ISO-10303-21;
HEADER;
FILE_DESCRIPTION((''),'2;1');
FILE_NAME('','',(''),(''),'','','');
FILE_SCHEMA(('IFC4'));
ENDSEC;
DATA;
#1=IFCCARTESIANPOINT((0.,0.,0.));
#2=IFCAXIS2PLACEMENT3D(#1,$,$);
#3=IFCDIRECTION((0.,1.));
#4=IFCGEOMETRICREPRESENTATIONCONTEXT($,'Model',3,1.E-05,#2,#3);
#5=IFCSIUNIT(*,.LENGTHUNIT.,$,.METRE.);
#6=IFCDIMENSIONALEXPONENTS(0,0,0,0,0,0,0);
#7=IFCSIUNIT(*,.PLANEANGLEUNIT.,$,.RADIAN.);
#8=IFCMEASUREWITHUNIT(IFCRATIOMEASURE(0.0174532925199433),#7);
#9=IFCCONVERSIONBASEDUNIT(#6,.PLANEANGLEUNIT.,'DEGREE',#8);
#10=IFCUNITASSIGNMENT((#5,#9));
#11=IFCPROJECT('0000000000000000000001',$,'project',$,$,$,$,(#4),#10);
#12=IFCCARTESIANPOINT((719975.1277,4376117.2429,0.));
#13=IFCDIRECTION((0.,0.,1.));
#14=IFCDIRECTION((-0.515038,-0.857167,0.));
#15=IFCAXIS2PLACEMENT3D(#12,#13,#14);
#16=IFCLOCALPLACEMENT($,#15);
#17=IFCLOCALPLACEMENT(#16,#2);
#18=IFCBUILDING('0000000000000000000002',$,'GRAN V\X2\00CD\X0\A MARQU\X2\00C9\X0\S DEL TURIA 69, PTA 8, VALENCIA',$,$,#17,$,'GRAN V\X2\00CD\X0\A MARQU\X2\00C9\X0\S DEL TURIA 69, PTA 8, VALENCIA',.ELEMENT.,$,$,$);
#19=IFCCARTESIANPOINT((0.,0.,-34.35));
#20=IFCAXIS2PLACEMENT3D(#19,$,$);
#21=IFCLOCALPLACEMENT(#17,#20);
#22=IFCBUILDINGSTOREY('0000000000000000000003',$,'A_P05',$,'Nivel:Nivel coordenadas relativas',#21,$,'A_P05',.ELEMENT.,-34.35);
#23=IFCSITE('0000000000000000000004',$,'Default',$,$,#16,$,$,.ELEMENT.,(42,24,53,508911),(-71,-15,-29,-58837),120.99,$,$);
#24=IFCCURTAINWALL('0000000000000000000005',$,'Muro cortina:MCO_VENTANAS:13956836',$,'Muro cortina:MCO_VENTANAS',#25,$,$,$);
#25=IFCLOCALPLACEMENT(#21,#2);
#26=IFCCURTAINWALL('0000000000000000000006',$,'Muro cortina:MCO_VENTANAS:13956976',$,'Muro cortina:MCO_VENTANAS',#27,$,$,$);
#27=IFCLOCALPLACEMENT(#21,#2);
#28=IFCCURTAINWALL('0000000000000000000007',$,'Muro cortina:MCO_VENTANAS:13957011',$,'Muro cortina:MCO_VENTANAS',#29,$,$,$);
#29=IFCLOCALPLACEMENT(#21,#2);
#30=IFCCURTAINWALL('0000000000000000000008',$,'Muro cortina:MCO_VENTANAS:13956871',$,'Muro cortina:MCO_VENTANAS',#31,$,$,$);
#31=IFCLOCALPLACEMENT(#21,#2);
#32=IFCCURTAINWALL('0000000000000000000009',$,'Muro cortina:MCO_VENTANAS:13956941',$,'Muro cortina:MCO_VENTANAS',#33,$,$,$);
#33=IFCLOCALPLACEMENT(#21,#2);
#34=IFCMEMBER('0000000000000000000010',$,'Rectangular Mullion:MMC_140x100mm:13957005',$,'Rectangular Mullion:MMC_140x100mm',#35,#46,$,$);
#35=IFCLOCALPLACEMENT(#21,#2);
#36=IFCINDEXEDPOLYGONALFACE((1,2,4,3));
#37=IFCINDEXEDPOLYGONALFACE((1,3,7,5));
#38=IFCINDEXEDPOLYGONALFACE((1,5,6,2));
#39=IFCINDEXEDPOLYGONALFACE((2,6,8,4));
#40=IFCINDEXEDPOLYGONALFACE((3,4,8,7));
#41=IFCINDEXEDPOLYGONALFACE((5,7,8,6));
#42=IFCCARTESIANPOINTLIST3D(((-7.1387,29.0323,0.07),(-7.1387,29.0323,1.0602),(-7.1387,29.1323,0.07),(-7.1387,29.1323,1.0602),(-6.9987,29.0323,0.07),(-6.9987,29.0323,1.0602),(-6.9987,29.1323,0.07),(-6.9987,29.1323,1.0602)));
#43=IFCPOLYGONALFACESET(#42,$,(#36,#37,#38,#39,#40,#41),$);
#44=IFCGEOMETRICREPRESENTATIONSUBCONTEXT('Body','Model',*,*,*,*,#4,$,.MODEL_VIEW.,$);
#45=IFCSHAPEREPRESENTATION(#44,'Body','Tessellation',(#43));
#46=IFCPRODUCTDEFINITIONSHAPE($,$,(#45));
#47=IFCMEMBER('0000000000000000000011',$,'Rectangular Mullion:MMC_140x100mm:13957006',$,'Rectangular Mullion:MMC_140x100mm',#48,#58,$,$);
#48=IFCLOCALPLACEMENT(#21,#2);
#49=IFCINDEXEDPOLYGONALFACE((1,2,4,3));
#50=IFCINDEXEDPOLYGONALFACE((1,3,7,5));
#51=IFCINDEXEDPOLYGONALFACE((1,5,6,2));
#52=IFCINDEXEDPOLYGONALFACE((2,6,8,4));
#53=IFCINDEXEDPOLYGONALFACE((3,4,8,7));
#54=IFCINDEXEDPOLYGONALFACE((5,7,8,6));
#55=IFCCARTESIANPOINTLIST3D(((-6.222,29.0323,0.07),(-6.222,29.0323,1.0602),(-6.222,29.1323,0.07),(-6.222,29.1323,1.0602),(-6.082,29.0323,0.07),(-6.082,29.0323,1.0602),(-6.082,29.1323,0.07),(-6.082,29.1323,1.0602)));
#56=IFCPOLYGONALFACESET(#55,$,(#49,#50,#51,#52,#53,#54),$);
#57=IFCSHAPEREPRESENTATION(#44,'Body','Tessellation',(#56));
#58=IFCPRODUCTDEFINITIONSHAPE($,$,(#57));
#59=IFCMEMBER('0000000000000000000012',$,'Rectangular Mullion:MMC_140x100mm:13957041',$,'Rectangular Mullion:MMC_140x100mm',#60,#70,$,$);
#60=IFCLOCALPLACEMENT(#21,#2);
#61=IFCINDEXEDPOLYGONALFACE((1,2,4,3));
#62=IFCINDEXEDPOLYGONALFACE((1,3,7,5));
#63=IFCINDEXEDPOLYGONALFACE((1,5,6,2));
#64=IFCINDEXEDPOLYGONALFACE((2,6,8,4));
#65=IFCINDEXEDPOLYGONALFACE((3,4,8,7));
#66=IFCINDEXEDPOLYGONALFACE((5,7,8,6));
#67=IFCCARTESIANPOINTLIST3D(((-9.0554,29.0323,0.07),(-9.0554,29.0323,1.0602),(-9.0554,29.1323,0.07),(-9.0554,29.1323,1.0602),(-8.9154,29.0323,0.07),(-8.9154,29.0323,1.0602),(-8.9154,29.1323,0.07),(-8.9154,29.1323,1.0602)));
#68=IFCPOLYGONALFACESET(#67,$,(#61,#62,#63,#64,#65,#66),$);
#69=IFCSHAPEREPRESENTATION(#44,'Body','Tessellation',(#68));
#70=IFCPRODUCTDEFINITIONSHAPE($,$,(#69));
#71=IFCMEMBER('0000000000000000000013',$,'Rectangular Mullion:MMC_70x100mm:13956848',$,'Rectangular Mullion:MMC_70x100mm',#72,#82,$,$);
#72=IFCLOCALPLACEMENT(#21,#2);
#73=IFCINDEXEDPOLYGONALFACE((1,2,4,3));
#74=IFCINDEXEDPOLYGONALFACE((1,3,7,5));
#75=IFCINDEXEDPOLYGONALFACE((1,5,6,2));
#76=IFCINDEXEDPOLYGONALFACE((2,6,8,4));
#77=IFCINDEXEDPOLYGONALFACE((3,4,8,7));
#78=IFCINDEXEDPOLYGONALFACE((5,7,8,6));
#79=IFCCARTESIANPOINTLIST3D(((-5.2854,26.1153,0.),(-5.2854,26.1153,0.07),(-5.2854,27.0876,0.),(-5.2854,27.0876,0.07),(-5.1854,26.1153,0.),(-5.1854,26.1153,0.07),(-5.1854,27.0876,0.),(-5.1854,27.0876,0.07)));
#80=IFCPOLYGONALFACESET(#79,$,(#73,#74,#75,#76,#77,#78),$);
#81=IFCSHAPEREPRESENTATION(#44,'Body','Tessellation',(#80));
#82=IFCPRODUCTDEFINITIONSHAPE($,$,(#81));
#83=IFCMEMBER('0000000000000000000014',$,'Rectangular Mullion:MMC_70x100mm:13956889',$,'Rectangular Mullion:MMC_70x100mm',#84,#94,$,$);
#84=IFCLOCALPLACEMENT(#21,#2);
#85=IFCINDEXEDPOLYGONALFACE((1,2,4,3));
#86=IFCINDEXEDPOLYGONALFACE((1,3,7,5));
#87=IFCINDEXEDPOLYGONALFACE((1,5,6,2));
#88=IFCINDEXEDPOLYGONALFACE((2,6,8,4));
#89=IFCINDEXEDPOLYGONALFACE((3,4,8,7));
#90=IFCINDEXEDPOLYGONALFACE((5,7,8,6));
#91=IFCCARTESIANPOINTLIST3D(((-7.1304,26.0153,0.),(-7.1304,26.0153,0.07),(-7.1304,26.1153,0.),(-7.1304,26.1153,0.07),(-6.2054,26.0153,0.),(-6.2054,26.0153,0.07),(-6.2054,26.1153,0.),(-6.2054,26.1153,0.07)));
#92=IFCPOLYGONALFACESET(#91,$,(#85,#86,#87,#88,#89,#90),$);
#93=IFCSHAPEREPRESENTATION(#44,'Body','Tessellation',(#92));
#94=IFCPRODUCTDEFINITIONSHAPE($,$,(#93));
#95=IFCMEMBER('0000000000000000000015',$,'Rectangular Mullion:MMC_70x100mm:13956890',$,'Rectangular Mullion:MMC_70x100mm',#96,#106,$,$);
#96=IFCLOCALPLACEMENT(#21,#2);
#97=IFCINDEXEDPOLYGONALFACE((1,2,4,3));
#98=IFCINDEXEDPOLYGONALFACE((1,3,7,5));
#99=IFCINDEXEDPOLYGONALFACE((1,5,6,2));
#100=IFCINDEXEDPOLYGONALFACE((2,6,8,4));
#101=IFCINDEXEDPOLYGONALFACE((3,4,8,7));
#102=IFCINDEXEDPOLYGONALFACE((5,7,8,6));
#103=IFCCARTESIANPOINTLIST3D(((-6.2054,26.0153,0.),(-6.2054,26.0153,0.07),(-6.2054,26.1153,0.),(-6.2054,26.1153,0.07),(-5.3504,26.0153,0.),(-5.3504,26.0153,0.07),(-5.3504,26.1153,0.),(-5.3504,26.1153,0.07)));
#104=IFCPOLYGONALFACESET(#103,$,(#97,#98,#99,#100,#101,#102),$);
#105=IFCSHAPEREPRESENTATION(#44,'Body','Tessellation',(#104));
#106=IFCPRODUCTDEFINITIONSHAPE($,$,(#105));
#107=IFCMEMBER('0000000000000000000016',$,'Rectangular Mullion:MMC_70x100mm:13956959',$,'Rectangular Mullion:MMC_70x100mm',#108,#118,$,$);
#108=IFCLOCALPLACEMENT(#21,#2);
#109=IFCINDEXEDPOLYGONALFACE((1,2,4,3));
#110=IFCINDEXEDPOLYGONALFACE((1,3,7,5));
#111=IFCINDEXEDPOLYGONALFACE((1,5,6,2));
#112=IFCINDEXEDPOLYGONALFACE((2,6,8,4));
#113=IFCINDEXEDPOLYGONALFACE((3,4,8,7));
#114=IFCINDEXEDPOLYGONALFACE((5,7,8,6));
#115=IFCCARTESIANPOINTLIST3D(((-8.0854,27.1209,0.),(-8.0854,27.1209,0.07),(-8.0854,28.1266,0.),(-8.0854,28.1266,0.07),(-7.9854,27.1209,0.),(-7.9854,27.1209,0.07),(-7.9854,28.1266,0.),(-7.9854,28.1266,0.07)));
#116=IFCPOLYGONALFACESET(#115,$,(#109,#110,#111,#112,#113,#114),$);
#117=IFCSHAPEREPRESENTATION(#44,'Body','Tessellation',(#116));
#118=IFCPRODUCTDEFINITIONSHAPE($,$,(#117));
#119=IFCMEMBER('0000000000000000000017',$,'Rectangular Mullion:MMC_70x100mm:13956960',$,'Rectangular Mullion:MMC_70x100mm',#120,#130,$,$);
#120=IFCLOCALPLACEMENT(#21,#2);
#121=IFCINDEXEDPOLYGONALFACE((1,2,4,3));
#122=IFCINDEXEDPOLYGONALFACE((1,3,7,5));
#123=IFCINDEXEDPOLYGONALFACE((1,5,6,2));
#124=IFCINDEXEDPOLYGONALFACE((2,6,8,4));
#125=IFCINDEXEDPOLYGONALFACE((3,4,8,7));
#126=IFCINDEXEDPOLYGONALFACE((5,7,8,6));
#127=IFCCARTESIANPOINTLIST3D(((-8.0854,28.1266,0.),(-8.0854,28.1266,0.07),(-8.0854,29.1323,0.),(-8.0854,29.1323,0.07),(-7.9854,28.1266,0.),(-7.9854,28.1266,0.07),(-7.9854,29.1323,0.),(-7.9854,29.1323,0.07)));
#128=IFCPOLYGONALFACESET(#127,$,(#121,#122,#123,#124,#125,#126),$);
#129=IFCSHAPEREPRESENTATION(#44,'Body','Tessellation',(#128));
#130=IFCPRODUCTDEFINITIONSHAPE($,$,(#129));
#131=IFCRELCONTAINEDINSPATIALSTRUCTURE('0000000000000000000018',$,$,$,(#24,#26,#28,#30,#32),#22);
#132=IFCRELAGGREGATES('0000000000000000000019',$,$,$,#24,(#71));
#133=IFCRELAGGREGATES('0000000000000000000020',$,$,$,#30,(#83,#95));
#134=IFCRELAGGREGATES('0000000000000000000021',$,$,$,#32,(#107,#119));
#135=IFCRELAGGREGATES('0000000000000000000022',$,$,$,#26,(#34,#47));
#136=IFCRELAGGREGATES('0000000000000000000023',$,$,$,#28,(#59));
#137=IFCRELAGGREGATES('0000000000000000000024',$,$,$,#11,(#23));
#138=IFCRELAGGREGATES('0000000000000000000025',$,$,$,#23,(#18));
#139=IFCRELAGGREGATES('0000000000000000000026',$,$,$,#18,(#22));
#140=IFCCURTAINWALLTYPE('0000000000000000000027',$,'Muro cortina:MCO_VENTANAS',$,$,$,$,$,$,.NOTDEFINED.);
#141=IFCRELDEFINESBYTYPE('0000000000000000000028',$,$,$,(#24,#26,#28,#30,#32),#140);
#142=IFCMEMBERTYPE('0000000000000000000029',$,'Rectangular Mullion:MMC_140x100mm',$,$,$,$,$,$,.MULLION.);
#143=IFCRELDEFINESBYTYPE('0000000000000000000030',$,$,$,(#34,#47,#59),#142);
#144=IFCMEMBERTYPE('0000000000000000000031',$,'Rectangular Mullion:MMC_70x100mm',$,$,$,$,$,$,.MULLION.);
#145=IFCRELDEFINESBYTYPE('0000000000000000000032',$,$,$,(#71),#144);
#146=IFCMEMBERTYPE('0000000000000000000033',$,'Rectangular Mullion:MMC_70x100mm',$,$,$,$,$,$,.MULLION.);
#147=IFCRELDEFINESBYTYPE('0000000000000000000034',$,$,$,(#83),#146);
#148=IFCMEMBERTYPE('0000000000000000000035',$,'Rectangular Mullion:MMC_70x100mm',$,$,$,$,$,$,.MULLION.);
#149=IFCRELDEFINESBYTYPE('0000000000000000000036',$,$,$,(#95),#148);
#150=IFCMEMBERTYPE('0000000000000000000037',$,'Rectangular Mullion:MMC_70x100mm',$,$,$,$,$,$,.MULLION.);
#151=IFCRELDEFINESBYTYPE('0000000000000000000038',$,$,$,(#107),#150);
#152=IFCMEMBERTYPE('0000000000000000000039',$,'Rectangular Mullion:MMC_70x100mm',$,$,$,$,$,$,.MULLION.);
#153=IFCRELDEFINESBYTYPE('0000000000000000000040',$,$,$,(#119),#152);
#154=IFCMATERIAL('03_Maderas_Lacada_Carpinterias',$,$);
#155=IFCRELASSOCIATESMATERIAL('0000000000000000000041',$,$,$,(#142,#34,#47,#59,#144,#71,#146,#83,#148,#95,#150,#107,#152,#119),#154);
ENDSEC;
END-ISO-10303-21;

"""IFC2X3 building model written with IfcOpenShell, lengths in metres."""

from ifc_helpers import new_model, entity, si_unit, converted_unit, direction, frame, origin, origin_2d_with_axis, place, context, subcontext, project, spatial, rectangle, extrude, source, transform, mapped, material, type_object, type_shapes, element, aggregate, save


model = new_model("IFC2X3")

# Units and contexts
model_context = context("Model", 3, precision=1e-05, world=origin(), true_north=direction((0.0, 1.0)))
body_context = subcontext(model_context, "Body", "Model", "MODEL_VIEW")
ifc_project = project(units=[si_unit("LENGTHUNIT", "METRE"), converted_unit("PLANEANGLEUNIT", "DEGREE", entity("IfcRatioMeasure", 0.0174532925199433), si_unit("PLANEANGLEUNIT", "RADIAN"), dimensions=[0, 0, 0, 0, 0, 0, 0])], contexts=[model_context])

# Site, building, storey
site_placement = place(None, frame((719975.1277, 4376117.2429, 0.0), z_axis=(0.0, 0.0, 1.0), x_axis=(-0.515038, -0.857167, 0.0)))
site = spatial("IfcSite", under=ifc_project, at=site_placement, Name="Default", CompositionType="ELEMENT", RefLatitude=(42, 24, 53, 508911), RefLongitude=(-71, -15, -29, -58837), RefElevation=120.99)
building_placement = place(site_placement, origin())
building = spatial("IfcBuilding", under=site, at=building_placement, Name="GRAN VÍA MARQUÉS DEL TURIA 69, PTA 8, VALENCIA", LongName="GRAN VÍA MARQUÉS DEL TURIA 69, PTA 8, VALENCIA", CompositionType="ELEMENT")
storey_placement = place(building_placement, frame((0.0, 0.0, -34.35)))
storey = spatial("IfcBuildingStorey", under=building, at=storey_placement, Name="A_P05", ObjectType="Nivel:Nivel coordenadas relativas", LongName="A_P05", CompositionType="ELEMENT", Elevation=-34.35)

# Curtain wall
curtain_wall_type = type_object("IfcCurtainWallType", Name="Muro cortina:MCO_VENTANAS", PredefinedType="NOTDEFINED")
curtain_wall_1_placement = place(storey_placement, frame((0.0, 0.0, 34.35)))
curtain_wall_1 = element("IfcCurtainWall", 1, at=curtain_wall_1_placement, inside=storey, type_object=curtain_wall_type, Name="Muro cortina:MCO_VENTANAS:13956836", ObjectType="Muro cortina:MCO_VENTANAS")
ifc_material_1 = material(Name="03_Maderas_Lacada_Carpinterias")

# Curtain wall
curtain_wall_2_placement = place(storey_placement, frame((0.0, 0.0, 34.35)))
curtain_wall_2 = element("IfcCurtainWall", 2, at=curtain_wall_2_placement, inside=storey, type_object=curtain_wall_type, Name="Muro cortina:MCO_VENTANAS:13956976", ObjectType="Muro cortina:MCO_VENTANAS")

# Curtain walls
curtain_wall_3_placement = place(storey_placement, frame((0.0, 0.0, 34.35)))
curtain_wall_3 = element("IfcCurtainWall", 3, at=curtain_wall_3_placement, inside=storey, type_object=curtain_wall_type, Name="Muro cortina:MCO_VENTANAS:13957011", ObjectType="Muro cortina:MCO_VENTANAS")
curtain_wall_4_placement = place(storey_placement, frame((0.0, 0.0, 34.35)))
curtain_wall_4 = element("IfcCurtainWall", 4, at=curtain_wall_4_placement, inside=storey, type_object=curtain_wall_type, Name="Muro cortina:MCO_VENTANAS:13956871", ObjectType="Muro cortina:MCO_VENTANAS")
curtain_wall_5_placement = place(storey_placement, frame((0.0, 0.0, 34.35)))
curtain_wall_5 = element("IfcCurtainWall", 5, at=curtain_wall_5_placement, inside=storey, type_object=curtain_wall_type, Name="Muro cortina:MCO_VENTANAS:13956941", ObjectType="Muro cortina:MCO_VENTANAS")

# Members
member_type_1 = type_object("IfcMemberType", Name="Rectangular Mullion:MMC_140x100mm", PredefinedType="MULLION", material=ifc_material_1)
shared_shape_1 = source(origin(), body_context, "Body", "SweptSolid", [
    extrude(rectangle(XDim=0.1, YDim=0.14, at=origin_2d_with_axis()), frame((0.0, 0.0, -0.9902), z_axis=(0.0, 0.0, 1.0), x_axis=(0.0, -1.0, 0.0)), (0.0, 0.0, 1.0), 0.9902),
])
type_shapes(member_type_1, [shared_shape_1])
member_1_placement = place(storey_placement, frame((-7.0687, 29.0823, 0.07), z_axis=(0.0, 0.0, -1.0), x_axis=(1.0, 0.0, 0.0)))
member_1 = element("IfcMember", 6, at=member_1_placement, type_object=member_type_1, material=ifc_material_1, Name="Rectangular Mullion:MMC_140x100mm:13957005", ObjectType="Rectangular Mullion:MMC_140x100mm", context=body_context, shape_type="MappedRepresentation", body=[
    mapped(shared_shape_1, transform((0.0, 0.0, 0.0), scale=1.0)),
])
member_2_placement = place(storey_placement, frame((-6.152, 29.0823, 0.07), z_axis=(0.0, 0.0, -1.0), x_axis=(1.0, 0.0, 0.0)))
member_2 = element("IfcMember", 7, at=member_2_placement, type_object=member_type_1, material=ifc_material_1, Name="Rectangular Mullion:MMC_140x100mm:13957006", ObjectType="Rectangular Mullion:MMC_140x100mm", context=body_context, shape_type="MappedRepresentation", body=[
    mapped(shared_shape_1, transform((0.0, 0.0, 0.0), scale=1.0)),
])
member_3_placement = place(storey_placement, frame((-8.9854, 29.0823, 0.07), z_axis=(0.0, 0.0, -1.0), x_axis=(1.0, 0.0, 0.0)))
member_3 = element("IfcMember", 8, at=member_3_placement, type_object=member_type_1, material=ifc_material_1, Name="Rectangular Mullion:MMC_140x100mm:13957041", ObjectType="Rectangular Mullion:MMC_140x100mm", context=body_context, shape_type="MappedRepresentation", body=[
    mapped(shared_shape_1, transform((0.0, 0.0, 0.0), scale=1.0)),
])
member_type_2 = type_object("IfcMemberType", Name="Rectangular Mullion:MMC_70x100mm", PredefinedType="MULLION", material=ifc_material_1)
shared_shape_2 = source(origin(), body_context, "Body", "SweptSolid", [
    extrude(rectangle(XDim=0.1, YDim=0.07, at=origin_2d_with_axis()), frame((-0.035, 0.0, -0.9723), z_axis=(0.0, 0.0, 1.0), x_axis=(0.0, -1.0, 0.0)), (0.0, 0.0, 1.0), 0.9723),
])
type_shapes(member_type_2, [shared_shape_2])
member_4_placement = place(storey_placement, frame((-5.2354, 26.1153, 0.0), z_axis=(0.0, -1.0, 0.0), x_axis=(0.0, 0.0, -1.0)))
member_4 = element("IfcMember", 9, at=member_4_placement, type_object=member_type_2, material=ifc_material_1, Name="Rectangular Mullion:MMC_70x100mm:13956848", ObjectType="Rectangular Mullion:MMC_70x100mm", context=body_context, shape_type="MappedRepresentation", body=[
    mapped(shared_shape_2, transform((0.0, 0.0, 0.0), scale=1.0)),
])
member_type_3 = type_object("IfcMemberType", Name="Rectangular Mullion:MMC_70x100mm", PredefinedType="MULLION", material=ifc_material_1)
shared_shape_3 = source(origin(), body_context, "Body", "SweptSolid", [
    extrude(rectangle(XDim=0.1, YDim=0.07, at=origin_2d_with_axis()), frame((-0.035, 0.0, -0.925), z_axis=(0.0, 0.0, 1.0), x_axis=(0.0, -1.0, 0.0)), (0.0, 0.0, 1.0), 0.925),
])
type_shapes(member_type_3, [shared_shape_3])
member_5_placement = place(storey_placement, frame((-7.1304, 26.0653, 0.0), z_axis=(-1.0, 0.0, 0.0), x_axis=(0.0, 0.0, -1.0)))
member_5 = element("IfcMember", 10, at=member_5_placement, type_object=member_type_3, material=ifc_material_1, Name="Rectangular Mullion:MMC_70x100mm:13956889", ObjectType="Rectangular Mullion:MMC_70x100mm", context=body_context, shape_type="MappedRepresentation", body=[
    mapped(shared_shape_3, transform((0.0, 0.0, 0.0), scale=1.0)),
])
member_type_4 = type_object("IfcMemberType", Name="Rectangular Mullion:MMC_70x100mm", PredefinedType="MULLION", material=ifc_material_1)
shared_shape_4 = source(origin(), body_context, "Body", "SweptSolid", [
    extrude(rectangle(XDim=0.1, YDim=0.07, at=origin_2d_with_axis()), frame((-0.035, 0.0, -0.855), z_axis=(0.0, 0.0, 1.0), x_axis=(0.0, -1.0, 0.0)), (0.0, 0.0, 1.0), 0.855),
])
type_shapes(member_type_4, [shared_shape_4])
member_6_placement = place(storey_placement, frame((-6.2054, 26.0653, 0.0), z_axis=(-1.0, 0.0, 0.0), x_axis=(0.0, 0.0, -1.0)))
member_6 = element("IfcMember", 11, at=member_6_placement, type_object=member_type_4, material=ifc_material_1, Name="Rectangular Mullion:MMC_70x100mm:13956890", ObjectType="Rectangular Mullion:MMC_70x100mm", context=body_context, shape_type="MappedRepresentation", body=[
    mapped(shared_shape_4, transform((0.0, 0.0, 0.0), scale=1.0)),
])
member_type_5 = type_object("IfcMemberType", Name="Rectangular Mullion:MMC_70x100mm", PredefinedType="MULLION", material=ifc_material_1)
shared_shape_5 = source(origin(), body_context, "Body", "SweptSolid", [
    extrude(rectangle(XDim=0.1, YDim=0.07, at=origin_2d_with_axis()), frame((-0.035, 0.0, -1.0057), z_axis=(0.0, 0.0, 1.0), x_axis=(0.0, -1.0, 0.0)), (0.0, 0.0, 1.0), 1.0057),
])
type_shapes(member_type_5, [shared_shape_5])
member_7_placement = place(storey_placement, frame((-8.0354, 27.1209, 0.0), z_axis=(0.0, -1.0, 0.0), x_axis=(0.0, 0.0, -1.0)))
member_7 = element("IfcMember", 12, at=member_7_placement, type_object=member_type_5, material=ifc_material_1, Name="Rectangular Mullion:MMC_70x100mm:13956959", ObjectType="Rectangular Mullion:MMC_70x100mm", context=body_context, shape_type="MappedRepresentation", body=[
    mapped(shared_shape_5, transform((0.0, 0.0, 0.0), scale=1.0)),
])
member_type_6 = type_object("IfcMemberType", Name="Rectangular Mullion:MMC_70x100mm", PredefinedType="MULLION", material=ifc_material_1)
shared_shape_6 = source(origin(), body_context, "Body", "SweptSolid", [
    extrude(rectangle(XDim=0.1, YDim=0.07, at=origin_2d_with_axis()), frame((-0.035, 0.0, -1.0057), z_axis=(0.0, 0.0, 1.0), x_axis=(0.0, -1.0, 0.0)), (0.0, 0.0, 1.0), 1.0057),
])
type_shapes(member_type_6, [shared_shape_6])
member_8_placement = place(storey_placement, frame((-8.0354, 28.1266, 0.0), z_axis=(0.0, -1.0, 0.0), x_axis=(0.0, 0.0, -1.0)))
member_8 = element("IfcMember", 13, at=member_8_placement, type_object=member_type_6, material=ifc_material_1, Name="Rectangular Mullion:MMC_70x100mm:13956960", ObjectType="Rectangular Mullion:MMC_70x100mm", context=body_context, shape_type="MappedRepresentation", body=[
    mapped(shared_shape_6, transform((0.0, 0.0, 0.0), scale=1.0)),
])

aggregate(curtain_wall_1, [member_4])
aggregate(curtain_wall_4, [member_5, member_6])
aggregate(curtain_wall_5, [member_7, member_8])
aggregate(curtain_wall_2, [member_1, member_2])
aggregate(curtain_wall_3, [member_3])

save(model, "model.ifc")
